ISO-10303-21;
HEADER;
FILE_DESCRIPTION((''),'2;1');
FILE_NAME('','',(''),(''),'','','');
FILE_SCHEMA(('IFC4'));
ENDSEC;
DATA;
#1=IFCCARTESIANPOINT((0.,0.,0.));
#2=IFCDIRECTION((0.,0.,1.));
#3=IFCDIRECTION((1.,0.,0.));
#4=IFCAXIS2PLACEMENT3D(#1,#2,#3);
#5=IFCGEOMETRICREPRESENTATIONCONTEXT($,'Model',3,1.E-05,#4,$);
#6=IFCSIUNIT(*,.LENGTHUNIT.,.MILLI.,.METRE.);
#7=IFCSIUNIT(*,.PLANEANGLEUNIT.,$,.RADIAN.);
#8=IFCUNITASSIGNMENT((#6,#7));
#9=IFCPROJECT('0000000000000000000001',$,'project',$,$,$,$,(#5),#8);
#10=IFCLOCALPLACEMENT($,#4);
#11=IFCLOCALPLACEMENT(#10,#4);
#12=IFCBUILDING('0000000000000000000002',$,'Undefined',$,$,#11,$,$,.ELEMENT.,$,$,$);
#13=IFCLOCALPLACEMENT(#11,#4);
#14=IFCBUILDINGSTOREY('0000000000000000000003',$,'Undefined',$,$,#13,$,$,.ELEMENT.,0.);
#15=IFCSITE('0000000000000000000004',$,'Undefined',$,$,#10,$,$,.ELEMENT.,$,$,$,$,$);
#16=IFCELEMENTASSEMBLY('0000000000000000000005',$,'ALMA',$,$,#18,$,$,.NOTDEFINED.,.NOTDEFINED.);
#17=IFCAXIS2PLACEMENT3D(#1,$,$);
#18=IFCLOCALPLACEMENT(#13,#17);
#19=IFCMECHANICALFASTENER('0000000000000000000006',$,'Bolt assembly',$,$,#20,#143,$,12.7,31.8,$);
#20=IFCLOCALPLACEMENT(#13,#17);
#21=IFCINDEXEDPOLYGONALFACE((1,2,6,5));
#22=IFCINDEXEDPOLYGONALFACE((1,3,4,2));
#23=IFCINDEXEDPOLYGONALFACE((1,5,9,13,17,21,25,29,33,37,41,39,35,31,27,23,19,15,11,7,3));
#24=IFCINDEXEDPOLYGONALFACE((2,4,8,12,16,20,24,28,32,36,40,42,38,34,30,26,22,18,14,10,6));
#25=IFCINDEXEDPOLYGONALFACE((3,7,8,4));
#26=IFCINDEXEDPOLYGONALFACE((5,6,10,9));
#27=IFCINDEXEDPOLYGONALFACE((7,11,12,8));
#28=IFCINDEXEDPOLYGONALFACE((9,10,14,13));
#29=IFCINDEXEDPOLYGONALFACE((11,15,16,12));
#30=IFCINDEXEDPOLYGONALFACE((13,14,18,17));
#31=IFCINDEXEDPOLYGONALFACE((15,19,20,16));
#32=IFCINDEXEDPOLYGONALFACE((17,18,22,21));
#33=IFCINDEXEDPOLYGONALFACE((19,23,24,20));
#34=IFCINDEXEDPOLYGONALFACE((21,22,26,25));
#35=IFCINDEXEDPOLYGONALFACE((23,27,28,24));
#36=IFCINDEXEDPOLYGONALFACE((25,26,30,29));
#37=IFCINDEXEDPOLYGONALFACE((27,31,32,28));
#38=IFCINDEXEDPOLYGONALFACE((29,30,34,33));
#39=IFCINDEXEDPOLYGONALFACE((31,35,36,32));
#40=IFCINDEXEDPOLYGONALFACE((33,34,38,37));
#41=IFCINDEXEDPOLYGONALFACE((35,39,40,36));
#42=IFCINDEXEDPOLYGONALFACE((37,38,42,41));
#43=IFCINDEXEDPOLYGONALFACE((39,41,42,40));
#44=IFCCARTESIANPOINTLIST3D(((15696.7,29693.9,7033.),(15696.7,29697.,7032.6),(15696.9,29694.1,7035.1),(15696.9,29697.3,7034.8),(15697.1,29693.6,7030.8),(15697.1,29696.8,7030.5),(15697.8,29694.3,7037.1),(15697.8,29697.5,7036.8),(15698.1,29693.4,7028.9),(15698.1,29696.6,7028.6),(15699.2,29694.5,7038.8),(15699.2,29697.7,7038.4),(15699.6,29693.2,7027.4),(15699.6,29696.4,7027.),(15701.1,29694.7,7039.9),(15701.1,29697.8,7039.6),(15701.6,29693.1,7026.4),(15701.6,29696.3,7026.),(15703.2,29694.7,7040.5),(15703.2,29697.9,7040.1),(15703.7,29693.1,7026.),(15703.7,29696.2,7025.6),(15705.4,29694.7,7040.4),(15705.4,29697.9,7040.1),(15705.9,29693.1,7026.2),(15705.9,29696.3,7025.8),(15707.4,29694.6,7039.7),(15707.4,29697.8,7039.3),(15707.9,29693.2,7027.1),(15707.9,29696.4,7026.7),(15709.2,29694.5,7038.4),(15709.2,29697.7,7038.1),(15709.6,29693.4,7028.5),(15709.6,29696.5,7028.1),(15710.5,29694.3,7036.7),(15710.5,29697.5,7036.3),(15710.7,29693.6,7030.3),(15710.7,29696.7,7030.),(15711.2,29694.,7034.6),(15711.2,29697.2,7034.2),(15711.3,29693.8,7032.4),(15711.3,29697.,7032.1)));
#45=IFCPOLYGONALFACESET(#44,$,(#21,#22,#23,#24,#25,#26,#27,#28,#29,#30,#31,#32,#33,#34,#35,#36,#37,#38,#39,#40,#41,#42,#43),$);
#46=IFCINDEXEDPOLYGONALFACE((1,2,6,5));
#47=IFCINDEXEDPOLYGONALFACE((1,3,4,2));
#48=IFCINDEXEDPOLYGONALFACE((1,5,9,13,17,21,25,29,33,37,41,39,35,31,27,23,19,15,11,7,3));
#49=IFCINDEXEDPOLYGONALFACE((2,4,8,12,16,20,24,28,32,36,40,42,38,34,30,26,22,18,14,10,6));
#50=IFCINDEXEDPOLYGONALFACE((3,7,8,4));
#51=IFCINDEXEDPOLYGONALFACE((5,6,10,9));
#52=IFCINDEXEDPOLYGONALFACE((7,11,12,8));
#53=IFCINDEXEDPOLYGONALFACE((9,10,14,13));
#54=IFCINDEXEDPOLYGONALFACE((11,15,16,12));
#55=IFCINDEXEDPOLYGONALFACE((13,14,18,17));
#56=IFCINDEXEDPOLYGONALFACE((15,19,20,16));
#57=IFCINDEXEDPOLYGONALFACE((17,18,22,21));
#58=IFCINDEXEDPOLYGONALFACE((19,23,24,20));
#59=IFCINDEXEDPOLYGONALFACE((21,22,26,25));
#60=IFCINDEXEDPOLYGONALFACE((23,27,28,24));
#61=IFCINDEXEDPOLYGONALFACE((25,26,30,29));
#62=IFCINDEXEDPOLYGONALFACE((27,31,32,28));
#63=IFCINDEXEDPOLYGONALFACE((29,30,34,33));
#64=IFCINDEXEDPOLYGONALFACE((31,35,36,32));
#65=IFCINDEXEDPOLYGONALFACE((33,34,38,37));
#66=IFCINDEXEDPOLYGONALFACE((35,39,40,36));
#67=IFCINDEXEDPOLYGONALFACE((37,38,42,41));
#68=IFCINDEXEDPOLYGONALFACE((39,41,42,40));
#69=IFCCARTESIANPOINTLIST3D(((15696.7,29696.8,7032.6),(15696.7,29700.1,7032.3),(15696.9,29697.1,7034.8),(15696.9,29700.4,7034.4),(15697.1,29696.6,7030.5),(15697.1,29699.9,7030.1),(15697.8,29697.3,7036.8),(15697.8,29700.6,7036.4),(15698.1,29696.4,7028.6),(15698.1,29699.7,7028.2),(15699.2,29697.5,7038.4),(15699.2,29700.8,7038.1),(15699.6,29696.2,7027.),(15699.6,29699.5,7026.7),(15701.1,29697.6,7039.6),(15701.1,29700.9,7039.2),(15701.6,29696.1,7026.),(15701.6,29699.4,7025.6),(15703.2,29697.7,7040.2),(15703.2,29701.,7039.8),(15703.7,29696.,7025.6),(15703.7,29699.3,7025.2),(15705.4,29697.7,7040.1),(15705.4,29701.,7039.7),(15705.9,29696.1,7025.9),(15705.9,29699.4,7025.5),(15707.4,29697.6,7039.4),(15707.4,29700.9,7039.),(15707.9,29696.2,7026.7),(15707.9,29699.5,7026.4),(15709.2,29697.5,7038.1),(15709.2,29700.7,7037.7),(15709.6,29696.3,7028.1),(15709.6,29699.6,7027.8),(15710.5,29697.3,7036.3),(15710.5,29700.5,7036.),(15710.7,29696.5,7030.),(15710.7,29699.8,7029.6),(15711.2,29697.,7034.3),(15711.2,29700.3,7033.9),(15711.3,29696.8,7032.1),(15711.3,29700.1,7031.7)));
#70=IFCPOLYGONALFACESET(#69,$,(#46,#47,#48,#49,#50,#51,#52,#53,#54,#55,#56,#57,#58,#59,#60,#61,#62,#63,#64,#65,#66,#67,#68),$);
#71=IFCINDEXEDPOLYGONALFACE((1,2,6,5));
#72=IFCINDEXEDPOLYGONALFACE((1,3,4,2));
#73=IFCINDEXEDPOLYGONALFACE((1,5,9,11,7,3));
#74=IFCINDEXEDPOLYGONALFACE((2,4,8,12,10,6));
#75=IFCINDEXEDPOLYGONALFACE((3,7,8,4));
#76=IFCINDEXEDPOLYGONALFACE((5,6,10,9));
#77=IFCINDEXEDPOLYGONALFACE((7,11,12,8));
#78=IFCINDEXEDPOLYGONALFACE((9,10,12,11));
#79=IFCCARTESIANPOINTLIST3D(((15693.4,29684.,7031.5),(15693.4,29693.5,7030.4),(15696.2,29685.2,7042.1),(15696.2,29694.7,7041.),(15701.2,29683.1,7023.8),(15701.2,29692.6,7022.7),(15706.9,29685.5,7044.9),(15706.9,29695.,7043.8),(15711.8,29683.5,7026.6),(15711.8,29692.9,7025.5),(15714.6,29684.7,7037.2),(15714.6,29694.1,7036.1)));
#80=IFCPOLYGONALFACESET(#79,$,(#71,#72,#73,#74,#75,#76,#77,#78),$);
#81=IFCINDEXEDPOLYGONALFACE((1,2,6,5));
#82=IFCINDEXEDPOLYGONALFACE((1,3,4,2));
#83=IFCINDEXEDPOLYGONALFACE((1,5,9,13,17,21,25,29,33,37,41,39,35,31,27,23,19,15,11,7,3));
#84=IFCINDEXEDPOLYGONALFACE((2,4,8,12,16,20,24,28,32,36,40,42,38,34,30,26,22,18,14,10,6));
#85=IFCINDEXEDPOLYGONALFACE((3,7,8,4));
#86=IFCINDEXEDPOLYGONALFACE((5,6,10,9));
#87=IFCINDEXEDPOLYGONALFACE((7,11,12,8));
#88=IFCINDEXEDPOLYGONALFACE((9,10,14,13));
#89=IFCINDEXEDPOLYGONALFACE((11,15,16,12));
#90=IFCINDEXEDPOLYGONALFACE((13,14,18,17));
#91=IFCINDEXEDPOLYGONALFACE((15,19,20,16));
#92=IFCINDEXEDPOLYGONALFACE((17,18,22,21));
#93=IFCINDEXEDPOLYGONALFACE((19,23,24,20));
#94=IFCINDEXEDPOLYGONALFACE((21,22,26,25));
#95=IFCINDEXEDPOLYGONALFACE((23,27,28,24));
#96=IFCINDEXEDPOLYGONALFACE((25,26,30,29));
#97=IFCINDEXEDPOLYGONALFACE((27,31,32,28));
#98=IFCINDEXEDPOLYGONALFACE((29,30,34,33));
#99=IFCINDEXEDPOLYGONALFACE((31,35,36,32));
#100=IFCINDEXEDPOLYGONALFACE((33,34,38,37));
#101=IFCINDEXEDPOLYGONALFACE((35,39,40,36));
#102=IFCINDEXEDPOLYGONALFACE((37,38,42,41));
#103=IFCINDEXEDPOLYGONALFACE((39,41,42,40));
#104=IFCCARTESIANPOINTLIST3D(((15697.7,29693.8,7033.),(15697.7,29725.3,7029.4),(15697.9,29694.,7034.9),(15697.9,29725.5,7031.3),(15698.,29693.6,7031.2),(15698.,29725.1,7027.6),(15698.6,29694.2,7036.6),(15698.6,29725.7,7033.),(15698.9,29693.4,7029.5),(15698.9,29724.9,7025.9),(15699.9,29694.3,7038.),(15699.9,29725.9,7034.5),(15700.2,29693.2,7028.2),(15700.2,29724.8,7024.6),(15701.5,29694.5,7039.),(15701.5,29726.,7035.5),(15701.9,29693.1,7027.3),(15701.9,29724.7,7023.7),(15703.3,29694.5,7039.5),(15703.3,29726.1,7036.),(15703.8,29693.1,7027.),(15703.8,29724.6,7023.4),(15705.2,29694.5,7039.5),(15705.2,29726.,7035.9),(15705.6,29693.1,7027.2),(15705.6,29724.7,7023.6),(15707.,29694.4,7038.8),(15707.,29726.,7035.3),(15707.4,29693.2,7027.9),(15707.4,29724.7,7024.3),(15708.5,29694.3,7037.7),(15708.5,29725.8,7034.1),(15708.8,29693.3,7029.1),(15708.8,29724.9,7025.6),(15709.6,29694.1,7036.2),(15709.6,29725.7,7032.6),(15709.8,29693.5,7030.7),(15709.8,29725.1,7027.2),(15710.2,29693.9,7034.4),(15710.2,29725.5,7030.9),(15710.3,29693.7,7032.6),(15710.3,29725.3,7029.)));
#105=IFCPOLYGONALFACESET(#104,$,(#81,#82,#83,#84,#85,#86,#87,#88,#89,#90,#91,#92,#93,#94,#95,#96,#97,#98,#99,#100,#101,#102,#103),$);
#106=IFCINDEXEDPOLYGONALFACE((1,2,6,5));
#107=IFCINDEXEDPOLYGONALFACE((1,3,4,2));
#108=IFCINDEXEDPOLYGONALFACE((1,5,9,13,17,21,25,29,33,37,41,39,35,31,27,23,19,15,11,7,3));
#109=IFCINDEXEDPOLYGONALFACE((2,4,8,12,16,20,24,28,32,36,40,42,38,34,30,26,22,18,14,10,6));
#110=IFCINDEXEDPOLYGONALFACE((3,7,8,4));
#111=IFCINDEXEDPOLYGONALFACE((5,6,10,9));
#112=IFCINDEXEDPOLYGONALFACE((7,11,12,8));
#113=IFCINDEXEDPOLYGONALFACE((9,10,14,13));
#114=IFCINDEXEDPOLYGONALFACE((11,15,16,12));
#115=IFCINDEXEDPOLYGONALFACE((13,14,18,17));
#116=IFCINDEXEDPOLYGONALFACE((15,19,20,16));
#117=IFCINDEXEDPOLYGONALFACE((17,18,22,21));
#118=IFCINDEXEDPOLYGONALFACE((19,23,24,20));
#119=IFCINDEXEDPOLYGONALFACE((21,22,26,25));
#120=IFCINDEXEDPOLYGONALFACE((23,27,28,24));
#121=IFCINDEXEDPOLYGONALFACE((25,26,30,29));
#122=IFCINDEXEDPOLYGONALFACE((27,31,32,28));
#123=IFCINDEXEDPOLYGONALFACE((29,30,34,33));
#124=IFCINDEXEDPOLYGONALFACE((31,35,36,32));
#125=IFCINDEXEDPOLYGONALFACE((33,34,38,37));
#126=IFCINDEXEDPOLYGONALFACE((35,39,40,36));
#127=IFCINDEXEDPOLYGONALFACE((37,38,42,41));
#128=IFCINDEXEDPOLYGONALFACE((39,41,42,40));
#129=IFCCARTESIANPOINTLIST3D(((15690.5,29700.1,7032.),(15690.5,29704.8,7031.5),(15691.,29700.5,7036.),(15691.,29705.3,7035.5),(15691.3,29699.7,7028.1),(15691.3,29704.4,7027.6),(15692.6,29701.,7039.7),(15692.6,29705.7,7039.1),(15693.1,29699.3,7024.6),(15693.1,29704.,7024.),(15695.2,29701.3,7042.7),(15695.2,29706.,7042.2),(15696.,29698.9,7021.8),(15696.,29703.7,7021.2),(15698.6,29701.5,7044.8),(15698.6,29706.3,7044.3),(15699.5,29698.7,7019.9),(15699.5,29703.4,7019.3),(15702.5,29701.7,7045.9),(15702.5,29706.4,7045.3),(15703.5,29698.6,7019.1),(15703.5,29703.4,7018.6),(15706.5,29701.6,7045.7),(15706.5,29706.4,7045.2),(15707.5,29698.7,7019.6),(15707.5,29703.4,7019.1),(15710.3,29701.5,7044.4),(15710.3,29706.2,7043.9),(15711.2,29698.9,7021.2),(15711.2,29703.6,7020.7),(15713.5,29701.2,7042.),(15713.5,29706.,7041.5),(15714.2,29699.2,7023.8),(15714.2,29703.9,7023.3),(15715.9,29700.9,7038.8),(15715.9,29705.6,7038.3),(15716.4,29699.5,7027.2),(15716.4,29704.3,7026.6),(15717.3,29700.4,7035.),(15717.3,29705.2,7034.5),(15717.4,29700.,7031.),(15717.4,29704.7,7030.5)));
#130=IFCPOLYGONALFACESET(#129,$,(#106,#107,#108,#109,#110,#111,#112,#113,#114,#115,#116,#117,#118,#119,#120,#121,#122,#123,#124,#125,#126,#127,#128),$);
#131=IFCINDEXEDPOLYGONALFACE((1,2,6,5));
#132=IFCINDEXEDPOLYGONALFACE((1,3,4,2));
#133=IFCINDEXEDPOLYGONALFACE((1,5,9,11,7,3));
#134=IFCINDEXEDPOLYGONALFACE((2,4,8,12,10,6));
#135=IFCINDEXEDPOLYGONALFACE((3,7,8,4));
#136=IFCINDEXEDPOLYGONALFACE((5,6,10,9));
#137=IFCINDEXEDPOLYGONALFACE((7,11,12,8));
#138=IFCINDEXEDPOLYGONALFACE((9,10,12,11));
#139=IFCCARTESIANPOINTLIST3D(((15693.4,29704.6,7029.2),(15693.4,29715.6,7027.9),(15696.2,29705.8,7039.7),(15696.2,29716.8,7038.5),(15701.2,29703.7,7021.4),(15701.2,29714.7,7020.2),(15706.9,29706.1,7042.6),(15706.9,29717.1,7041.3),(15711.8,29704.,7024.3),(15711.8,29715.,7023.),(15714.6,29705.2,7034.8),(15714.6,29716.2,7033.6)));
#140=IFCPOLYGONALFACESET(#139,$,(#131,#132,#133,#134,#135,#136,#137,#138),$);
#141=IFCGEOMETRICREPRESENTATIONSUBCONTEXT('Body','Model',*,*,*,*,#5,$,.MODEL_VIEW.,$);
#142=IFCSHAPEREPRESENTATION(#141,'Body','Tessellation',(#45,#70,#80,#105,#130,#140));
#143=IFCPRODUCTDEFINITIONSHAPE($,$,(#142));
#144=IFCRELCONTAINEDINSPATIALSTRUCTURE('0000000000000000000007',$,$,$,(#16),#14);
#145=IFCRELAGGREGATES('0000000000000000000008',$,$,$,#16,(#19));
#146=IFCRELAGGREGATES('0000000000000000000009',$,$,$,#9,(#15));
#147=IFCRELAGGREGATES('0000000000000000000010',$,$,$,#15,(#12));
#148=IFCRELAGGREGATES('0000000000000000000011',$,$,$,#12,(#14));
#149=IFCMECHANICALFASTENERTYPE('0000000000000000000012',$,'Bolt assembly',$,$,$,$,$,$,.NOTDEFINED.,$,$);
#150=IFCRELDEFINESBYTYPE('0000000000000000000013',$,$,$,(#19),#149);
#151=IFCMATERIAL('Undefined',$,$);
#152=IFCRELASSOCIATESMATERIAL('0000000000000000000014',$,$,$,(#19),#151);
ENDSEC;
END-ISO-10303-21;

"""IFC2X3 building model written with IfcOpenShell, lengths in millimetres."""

from ifc_helpers import new_model, si_unit, frame, origin_with_axes, origin_2d_with_axis, place, context, subcontext, project, spatial, polyline, circle, outline, extrude, source, transform, mapped, material, type_object, element, aggregate, save


model = new_model("IFC2X3")

# Units and contexts
model_context = context("Model", 3, precision=1e-05, world=origin_with_axes())
body_context = subcontext(model_context, "Body", "Model", "MODEL_VIEW")
ifc_project = project(units=[si_unit("LENGTHUNIT", "METRE", prefix="MILLI"), si_unit("PLANEANGLEUNIT", "RADIAN")], contexts=[model_context])

# Site, building, storey
site_placement = place(None, origin_with_axes())
site = spatial("IfcSite", under=ifc_project, at=site_placement, Name="Undefined", CompositionType="ELEMENT")
building_placement = place(site_placement, origin_with_axes())
building = spatial("IfcBuilding", under=site, at=building_placement, Name="Undefined", CompositionType="ELEMENT")
storey_placement = place(building_placement, origin_with_axes())
storey = spatial("IfcBuildingStorey", under=building, at=storey_placement, Name="Undefined", CompositionType="ELEMENT", Elevation=0.0)

# Element assembly
assembly_1_placement = place(storey_placement, origin_with_axes())
assembly_1 = element("IfcElementAssembly", 1, at=assembly_1_placement, inside=storey, Name="ALMA", AssemblyPlace="NOTDEFINED", PredefinedType="NOTDEFINED")

# Shared definitions
ifc_material_1 = material(Name="Undefined")
mechanical_fastener_type = type_object("IfcMechanicalFastenerType", Name="Bolt assembly")

# Mechanical fastener
shared_shape_1 = source(origin_with_axes(), body_context, "Body", "SweptSolid", [
    extrude(circle(Radius=7.3, at=origin_2d_with_axis()), frame((0.0, 0.1, 0.0), z_axis=(0.0, 1.0, 0.0), x_axis=(1.0, 0.0, 0.0)), (0.0, 0.0, 1.0), 3.2),
    extrude(circle(Radius=7.3, at=origin_2d_with_axis()), frame((0.0, 3.1, 0.0), z_axis=(0.0, 1.0, 0.0), x_axis=(1.0, 0.0, 0.0)), (0.0, 0.0, 1.0), 3.3),
    extrude(outline(polyline([(9.5, -5.5), (9.5, 5.5), (0.0, 11.0), (-9.5, 5.5), (-9.5, -5.5), (0.0, -11.0), (9.5, -5.5)])), frame((0.0, -9.5, 0.0), z_axis=(0.0, 1.0, 0.0), x_axis=(1.0, 0.0, 0.0)), (0.0, 0.0, 1.0), 9.5),
    extrude(circle(Radius=6.3, at=origin_2d_with_axis()), frame((0.0, 0.0, 0.0), z_axis=(0.0, 1.0, 0.0), x_axis=(1.0, 0.0, 0.0)), (0.0, 0.0, 1.0), 31.8),
    extrude(circle(Radius=13.5, at=origin_2d_with_axis()), frame((0.0, 6.4, 0.0), z_axis=(0.0, 1.0, 0.0), x_axis=(1.0, 0.0, 0.0)), (0.0, 0.0, 1.0), 4.8),
    extrude(outline(polyline([(9.5, -5.5), (9.5, 5.5), (0.0, 11.0), (-9.5, 5.5), (-9.5, -5.5), (0.0, -11.0), (9.5, -5.5)])), frame((0.0, 11.2, 0.0), z_axis=(0.0, 1.0, 0.0), x_axis=(1.0, 0.0, 0.0)), (0.0, 0.0, 1.0), 11.1),
])
mechanical_fastener_1_placement = place(assembly_1_placement, frame((15704.0, 29693.8, 7033.3), z_axis=(-0.707107, 0.079651, 0.702606), x_axis=(0.707107, 0.079651, 0.702606)))
mechanical_fastener_1 = element("IfcMechanicalFastener", 2, at=mechanical_fastener_1_placement, type_object=mechanical_fastener_type, material=ifc_material_1, Name="Bolt assembly", NominalDiameter=12.7, NominalLength=31.8, context=body_context, shape_type="MappedRepresentation", body=[
    mapped(shared_shape_1, transform((0.0, 0.0, 0.0))),
])
aggregate(assembly_1, [mechanical_fastener_1])

save(model, "model.ifc")
